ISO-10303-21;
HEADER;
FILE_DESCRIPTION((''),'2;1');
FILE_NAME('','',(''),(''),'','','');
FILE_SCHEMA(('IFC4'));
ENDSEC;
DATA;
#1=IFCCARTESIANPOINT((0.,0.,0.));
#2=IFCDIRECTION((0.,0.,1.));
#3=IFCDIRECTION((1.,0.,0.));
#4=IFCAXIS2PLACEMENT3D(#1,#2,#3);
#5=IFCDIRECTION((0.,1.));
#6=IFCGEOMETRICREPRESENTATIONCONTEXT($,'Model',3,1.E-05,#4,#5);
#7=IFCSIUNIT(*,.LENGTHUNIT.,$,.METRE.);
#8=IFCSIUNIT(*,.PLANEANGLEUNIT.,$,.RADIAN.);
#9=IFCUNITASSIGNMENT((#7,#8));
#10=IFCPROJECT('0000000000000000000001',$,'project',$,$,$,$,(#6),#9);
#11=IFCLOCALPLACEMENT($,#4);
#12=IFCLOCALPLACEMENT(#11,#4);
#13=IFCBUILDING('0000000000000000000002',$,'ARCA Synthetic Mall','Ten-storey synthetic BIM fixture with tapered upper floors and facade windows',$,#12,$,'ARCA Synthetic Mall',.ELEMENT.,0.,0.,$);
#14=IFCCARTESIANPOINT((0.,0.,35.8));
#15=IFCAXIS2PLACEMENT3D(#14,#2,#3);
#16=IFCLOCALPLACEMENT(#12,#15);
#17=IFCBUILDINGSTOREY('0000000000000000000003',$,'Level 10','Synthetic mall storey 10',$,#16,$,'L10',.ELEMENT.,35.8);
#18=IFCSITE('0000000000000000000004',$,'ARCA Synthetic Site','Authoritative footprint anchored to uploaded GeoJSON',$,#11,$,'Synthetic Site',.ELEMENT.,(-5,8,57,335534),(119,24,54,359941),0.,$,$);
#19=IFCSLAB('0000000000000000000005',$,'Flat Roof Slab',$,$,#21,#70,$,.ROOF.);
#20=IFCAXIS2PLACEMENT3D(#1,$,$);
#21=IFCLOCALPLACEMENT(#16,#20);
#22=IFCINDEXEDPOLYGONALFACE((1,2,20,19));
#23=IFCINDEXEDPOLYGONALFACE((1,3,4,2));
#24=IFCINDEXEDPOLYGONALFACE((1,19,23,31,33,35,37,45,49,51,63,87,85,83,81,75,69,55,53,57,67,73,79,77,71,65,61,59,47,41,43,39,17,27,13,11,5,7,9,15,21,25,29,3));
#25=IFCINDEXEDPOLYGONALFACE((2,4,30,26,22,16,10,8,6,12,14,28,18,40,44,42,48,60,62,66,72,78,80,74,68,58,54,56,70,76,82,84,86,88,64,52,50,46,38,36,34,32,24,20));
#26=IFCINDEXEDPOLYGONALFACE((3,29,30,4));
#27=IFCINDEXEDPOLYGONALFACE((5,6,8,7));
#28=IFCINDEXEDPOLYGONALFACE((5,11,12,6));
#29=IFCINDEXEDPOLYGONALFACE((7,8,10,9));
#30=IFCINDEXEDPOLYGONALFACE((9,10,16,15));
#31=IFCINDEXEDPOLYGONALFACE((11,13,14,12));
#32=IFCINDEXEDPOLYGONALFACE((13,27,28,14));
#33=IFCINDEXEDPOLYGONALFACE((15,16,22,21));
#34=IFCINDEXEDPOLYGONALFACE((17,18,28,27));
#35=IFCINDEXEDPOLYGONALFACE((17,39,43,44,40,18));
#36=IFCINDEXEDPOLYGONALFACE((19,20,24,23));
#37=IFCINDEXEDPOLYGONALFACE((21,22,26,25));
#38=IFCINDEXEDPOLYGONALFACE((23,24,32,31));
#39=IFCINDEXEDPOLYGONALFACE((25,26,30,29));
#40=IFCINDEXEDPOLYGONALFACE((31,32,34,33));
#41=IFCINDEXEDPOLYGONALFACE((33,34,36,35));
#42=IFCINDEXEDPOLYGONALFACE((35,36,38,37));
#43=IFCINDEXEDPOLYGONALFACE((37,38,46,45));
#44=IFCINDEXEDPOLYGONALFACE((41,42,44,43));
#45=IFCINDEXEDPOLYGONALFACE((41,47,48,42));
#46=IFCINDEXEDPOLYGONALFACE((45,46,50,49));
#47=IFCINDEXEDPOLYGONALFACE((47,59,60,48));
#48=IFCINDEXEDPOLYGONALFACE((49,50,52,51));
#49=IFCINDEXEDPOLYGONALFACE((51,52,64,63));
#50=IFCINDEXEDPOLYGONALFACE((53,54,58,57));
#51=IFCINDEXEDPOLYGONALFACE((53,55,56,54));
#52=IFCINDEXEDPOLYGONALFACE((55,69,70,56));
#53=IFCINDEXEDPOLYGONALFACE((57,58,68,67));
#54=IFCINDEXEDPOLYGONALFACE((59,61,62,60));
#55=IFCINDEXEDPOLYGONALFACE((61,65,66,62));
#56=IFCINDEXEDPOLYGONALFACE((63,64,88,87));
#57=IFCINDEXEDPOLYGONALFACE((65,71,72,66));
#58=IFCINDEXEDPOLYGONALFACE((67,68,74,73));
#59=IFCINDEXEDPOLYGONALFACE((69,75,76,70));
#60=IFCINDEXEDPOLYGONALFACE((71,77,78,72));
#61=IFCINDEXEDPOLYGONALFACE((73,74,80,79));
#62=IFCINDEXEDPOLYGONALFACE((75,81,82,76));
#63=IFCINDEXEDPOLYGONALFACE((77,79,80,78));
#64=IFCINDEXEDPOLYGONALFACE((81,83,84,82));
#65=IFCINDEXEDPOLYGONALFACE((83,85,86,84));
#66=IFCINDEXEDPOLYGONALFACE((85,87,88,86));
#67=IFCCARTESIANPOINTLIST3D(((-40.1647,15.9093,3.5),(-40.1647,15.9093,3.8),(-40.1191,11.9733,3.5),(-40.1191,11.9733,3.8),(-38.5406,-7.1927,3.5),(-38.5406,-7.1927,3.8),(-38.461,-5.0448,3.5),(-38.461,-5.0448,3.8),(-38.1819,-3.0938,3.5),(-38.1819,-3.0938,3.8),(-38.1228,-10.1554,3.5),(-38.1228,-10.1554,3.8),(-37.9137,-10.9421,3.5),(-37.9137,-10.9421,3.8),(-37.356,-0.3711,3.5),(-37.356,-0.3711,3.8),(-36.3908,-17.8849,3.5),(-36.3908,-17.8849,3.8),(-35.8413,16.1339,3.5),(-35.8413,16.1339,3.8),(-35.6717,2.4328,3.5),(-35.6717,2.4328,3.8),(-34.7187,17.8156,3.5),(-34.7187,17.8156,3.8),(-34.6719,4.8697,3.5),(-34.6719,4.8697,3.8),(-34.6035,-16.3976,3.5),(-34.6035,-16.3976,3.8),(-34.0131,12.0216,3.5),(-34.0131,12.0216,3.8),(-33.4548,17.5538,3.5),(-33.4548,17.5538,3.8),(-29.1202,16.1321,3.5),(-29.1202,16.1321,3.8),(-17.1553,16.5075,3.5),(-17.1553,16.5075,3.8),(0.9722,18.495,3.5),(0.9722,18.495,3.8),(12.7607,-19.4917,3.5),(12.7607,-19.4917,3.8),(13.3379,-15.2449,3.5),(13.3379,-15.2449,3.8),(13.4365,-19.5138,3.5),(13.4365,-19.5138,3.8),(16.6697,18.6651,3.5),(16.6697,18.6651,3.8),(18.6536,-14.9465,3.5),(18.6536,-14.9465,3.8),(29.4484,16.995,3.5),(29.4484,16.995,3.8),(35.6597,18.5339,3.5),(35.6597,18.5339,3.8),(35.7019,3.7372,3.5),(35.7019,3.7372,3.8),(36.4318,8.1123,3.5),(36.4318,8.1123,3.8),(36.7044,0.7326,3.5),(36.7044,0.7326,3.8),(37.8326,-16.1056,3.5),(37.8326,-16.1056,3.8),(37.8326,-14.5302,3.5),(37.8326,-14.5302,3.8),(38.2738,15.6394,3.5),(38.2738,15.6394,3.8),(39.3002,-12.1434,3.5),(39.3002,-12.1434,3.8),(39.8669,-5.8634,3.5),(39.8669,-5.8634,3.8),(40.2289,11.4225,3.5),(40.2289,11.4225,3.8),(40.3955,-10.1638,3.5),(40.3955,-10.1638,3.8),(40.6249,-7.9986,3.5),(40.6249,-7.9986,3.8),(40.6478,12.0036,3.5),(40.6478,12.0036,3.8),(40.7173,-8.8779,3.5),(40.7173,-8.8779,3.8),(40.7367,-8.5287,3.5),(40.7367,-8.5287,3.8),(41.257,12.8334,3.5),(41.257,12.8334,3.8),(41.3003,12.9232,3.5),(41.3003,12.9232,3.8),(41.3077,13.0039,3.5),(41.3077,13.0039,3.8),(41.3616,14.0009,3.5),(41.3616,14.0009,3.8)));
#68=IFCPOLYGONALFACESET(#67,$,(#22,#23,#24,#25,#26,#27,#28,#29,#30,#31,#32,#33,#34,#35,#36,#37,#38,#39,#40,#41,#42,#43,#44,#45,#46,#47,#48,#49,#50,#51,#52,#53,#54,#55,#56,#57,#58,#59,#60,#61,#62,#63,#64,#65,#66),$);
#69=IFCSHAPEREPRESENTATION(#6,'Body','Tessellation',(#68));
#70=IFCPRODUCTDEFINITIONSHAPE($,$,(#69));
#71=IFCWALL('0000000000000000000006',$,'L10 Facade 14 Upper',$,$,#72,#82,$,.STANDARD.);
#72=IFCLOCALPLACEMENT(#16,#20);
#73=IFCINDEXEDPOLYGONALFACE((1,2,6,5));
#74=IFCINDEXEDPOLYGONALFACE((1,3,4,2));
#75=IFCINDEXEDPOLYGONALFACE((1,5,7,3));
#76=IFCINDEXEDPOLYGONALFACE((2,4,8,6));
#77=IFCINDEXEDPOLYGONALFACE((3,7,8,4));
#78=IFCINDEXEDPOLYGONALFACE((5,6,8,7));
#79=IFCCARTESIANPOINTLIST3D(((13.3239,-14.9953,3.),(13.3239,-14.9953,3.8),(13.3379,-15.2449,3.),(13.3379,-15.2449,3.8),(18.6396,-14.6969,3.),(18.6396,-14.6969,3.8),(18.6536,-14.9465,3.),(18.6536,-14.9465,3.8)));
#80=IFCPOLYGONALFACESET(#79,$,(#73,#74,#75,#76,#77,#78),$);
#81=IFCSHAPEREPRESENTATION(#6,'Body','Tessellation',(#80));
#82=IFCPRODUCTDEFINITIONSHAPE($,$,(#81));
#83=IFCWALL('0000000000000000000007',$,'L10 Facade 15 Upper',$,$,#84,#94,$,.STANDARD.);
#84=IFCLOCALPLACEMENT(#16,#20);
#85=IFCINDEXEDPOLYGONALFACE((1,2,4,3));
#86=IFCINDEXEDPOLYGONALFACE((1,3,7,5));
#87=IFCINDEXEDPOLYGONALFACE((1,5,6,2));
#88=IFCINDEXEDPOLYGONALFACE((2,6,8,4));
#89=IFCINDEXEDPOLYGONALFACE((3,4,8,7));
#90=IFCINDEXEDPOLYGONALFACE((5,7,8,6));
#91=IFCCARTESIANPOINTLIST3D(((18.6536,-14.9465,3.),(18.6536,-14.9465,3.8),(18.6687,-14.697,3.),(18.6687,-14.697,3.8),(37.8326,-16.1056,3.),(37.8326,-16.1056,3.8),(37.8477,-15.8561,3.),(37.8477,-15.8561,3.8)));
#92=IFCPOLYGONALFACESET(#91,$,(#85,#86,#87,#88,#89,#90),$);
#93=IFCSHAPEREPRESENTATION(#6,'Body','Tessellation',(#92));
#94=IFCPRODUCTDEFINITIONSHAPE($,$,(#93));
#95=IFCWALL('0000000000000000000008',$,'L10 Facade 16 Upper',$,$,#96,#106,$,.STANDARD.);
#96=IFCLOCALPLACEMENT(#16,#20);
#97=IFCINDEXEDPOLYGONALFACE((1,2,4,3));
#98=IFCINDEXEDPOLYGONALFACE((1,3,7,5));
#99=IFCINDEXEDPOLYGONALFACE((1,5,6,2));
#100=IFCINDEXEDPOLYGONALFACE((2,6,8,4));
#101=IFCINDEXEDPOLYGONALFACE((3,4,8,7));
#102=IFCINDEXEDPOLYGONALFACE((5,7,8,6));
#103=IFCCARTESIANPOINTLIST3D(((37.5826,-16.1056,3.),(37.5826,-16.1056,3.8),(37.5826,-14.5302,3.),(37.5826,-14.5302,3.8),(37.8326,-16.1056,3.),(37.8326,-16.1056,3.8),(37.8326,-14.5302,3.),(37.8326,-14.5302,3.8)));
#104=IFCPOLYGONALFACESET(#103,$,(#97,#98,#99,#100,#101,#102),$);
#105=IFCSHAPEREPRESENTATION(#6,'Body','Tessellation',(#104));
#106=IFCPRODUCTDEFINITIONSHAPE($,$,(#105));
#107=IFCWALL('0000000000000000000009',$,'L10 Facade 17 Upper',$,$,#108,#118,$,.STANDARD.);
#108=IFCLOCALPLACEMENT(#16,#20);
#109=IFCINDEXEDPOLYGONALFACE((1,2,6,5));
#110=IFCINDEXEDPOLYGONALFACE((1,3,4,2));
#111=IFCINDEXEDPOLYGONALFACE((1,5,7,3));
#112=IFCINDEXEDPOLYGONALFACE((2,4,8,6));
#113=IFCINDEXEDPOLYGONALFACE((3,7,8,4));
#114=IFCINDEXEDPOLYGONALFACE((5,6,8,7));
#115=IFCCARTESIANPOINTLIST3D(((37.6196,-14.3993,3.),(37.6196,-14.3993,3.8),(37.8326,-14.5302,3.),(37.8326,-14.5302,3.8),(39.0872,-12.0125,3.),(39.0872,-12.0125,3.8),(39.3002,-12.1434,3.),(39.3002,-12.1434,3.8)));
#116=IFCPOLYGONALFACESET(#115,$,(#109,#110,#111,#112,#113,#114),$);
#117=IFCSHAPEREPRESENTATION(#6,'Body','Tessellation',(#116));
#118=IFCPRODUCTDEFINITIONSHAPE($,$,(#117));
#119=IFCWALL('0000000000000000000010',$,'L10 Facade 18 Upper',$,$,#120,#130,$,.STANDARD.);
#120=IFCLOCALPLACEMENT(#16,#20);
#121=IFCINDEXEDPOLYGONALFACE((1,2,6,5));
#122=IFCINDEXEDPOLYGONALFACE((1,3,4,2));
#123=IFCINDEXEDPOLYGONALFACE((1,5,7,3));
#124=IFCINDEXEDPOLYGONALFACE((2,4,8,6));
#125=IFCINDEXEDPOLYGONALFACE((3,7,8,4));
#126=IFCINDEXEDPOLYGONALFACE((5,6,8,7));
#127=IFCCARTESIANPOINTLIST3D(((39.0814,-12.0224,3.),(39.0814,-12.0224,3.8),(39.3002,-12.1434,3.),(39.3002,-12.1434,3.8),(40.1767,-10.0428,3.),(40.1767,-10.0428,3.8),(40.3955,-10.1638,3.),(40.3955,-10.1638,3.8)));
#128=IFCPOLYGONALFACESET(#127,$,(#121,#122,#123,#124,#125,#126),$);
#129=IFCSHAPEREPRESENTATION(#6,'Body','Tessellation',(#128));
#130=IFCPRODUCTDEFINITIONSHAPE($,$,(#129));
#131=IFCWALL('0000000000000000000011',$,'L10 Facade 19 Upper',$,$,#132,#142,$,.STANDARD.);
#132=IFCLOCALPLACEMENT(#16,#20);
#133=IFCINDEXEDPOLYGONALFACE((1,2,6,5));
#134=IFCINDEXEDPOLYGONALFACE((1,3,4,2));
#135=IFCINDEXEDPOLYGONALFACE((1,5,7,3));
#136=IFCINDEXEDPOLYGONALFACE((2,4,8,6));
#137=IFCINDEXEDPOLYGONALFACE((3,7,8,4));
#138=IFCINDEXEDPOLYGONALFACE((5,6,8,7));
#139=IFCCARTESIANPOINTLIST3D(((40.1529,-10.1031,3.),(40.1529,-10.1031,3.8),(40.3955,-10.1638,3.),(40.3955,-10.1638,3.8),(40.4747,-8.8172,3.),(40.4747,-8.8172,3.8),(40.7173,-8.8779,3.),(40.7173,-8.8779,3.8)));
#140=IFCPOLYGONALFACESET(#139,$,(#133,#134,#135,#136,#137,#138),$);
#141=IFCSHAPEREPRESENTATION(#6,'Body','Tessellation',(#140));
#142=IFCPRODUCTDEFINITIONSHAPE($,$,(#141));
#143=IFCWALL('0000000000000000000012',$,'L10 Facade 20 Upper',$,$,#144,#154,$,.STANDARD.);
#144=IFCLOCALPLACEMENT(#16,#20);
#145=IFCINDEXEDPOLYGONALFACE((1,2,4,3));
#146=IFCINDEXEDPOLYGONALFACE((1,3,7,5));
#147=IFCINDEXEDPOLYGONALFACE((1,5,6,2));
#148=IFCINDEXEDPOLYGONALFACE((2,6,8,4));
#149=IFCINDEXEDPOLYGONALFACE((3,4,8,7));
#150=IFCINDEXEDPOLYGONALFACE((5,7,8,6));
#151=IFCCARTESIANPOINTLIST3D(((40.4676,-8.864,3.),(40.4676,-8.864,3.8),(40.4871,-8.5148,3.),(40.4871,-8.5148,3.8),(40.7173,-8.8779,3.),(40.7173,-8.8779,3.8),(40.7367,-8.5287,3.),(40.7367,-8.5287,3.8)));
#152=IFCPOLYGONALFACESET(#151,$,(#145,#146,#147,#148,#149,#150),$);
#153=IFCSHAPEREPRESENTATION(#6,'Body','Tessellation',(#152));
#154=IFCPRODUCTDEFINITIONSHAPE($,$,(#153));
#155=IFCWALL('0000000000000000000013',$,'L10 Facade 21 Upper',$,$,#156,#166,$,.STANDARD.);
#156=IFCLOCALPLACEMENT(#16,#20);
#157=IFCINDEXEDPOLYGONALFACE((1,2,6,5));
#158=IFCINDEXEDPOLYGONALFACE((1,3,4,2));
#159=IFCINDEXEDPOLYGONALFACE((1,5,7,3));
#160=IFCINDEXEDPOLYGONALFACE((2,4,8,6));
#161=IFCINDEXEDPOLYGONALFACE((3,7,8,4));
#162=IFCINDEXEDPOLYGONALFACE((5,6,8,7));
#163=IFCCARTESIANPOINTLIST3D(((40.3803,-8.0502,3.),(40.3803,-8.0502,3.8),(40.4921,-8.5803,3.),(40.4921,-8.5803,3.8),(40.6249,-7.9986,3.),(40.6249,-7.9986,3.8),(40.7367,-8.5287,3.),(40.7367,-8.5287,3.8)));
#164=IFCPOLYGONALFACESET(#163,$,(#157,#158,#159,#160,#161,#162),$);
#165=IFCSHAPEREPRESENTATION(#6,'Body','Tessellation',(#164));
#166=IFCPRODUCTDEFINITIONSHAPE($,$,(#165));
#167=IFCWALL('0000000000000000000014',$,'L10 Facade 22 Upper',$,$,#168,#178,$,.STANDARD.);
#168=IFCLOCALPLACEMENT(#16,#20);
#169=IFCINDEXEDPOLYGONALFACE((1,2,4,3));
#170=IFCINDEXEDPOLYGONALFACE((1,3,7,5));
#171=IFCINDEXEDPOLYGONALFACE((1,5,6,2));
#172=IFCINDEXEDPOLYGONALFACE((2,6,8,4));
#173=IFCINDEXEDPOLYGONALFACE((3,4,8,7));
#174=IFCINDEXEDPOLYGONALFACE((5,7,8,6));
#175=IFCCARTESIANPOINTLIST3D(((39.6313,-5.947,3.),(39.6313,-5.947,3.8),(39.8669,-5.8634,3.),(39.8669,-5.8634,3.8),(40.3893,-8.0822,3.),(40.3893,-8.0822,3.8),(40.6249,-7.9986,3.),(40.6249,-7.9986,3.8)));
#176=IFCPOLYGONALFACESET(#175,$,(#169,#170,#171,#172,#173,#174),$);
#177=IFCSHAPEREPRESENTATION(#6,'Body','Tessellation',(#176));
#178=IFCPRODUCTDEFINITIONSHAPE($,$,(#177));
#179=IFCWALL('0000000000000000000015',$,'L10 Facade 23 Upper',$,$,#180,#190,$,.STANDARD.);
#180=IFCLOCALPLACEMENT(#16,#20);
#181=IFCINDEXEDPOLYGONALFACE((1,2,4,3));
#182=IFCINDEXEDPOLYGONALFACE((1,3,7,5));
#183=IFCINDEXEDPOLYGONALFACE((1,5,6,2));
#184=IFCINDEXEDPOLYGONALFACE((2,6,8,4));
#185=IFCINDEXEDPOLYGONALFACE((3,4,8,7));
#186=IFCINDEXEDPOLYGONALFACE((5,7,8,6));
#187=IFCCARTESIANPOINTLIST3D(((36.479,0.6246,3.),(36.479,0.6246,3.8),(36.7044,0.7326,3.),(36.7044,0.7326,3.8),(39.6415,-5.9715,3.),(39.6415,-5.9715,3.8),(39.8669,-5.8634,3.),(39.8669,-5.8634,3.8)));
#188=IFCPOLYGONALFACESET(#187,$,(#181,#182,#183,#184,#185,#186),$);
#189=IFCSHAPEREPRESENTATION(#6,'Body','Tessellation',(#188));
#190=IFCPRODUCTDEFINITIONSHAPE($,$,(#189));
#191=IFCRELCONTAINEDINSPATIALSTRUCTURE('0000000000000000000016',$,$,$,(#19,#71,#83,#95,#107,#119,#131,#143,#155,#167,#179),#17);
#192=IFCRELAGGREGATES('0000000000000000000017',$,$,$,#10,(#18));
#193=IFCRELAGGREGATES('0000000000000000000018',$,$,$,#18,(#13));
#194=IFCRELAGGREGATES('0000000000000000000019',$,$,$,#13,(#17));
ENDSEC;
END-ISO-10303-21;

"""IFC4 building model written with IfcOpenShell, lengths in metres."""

from ifc_helpers import new_model, si_unit, direction, frame, origin_with_axes, place, context, project, spatial, polyline, outline, extrude, element, save


model = new_model("IFC4")

# Units and contexts
model_context = context("Model", 3, precision=1e-05, world=origin_with_axes(), true_north=direction((0.0, 1.0)))
ifc_project = project(units=[si_unit("LENGTHUNIT", "METRE"), si_unit("PLANEANGLEUNIT", "RADIAN")], contexts=[model_context])

# Site, building, storey
site_placement = place(None, origin_with_axes())
site = spatial("IfcSite", under=ifc_project, at=site_placement, Name="ARCA Synthetic Site", Description="Authoritative footprint anchored to uploaded GeoJSON", LongName="Synthetic Site", CompositionType="ELEMENT", RefLatitude=(-5, 8, 57, 335534), RefLongitude=(119, 24, 54, 359941), RefElevation=0.0)
building_placement = place(site_placement, origin_with_axes())
building = spatial("IfcBuilding", under=site, at=building_placement, Name="ARCA Synthetic Mall", Description="Ten-storey synthetic BIM fixture with tapered upper floors and facade windows", LongName="ARCA Synthetic Mall", CompositionType="ELEMENT", ElevationOfRefHeight=0.0, ElevationOfTerrain=0.0)
storey_placement = place(building_placement, frame((0.0, 0.0, 35.8), z_axis=(0.0, 0.0, 1.0), x_axis=(1.0, 0.0, 0.0)))
storey = spatial("IfcBuildingStorey", under=building, at=storey_placement, Name="Level 10", Description="Synthetic mall storey 10", LongName="L10", CompositionType="ELEMENT", Elevation=35.8)

# Slab
slab_placement = place(storey_placement, frame((0.0, 0.0, 3.5), z_axis=(0.0, 0.0, 1.0), x_axis=(1.0, 0.0, 0.0)))
element("IfcSlab", 1, at=slab_placement, inside=storey, Name="Flat Roof Slab", PredefinedType="ROOF", context=model_context, shape_type="SweptSolid", body=[
    extrude(outline(polyline([(-40.1191, 11.9733), (-34.0131, 12.0216), (-34.6719, 4.8697), (-35.6717, 2.4328), (-37.356, -0.3711), (-38.1819, -3.0938), (-38.461, -5.0448), (-38.5406, -7.1927), (-38.1228, -10.1554), (-37.9137, -10.9421), (-34.6035, -16.3976), (-36.3908, -17.8849), (12.7607, -19.4917), (13.4365, -19.5138), (13.3379, -15.2449), (18.6536, -14.9465), (37.8326, -16.1056), (37.8326, -14.5302), (39.3002, -12.1434), (40.3955, -10.1638), (40.7173, -8.8779), (40.7367, -8.5287), (40.6249, -7.9986), (39.8669, -5.8634), (36.7044, 0.7326), (35.7019, 3.7372), (36.4318, 8.1123), (40.2289, 11.4225), (40.6478, 12.0036), (41.257, 12.8334), (41.3003, 12.9232), (41.3077, 13.0039), (41.3616, 14.0009), (38.2738, 15.6394), (35.6597, 18.5339), (29.4484, 16.995), (16.6697, 18.6651), (0.9722, 18.495), (-17.1553, 16.5075), (-29.1202, 16.1321), (-33.4548, 17.5538), (-34.7187, 17.8156), (-35.8413, 16.1339), (-40.1647, 15.9093), (-40.1191, 11.9733)])), origin_with_axes(), (0.0, 0.0, 1.0), 0.3),
])

# Walls
wall_1_placement = place(storey_placement, frame((0.0, 0.0, 3.0), z_axis=(0.0, 0.0, 1.0), x_axis=(1.0, 0.0, 0.0)))
element("IfcWall", 2, at=wall_1_placement, inside=storey, Name="L10 Facade 14 Upper", PredefinedType="STANDARD", context=model_context, shape_type="SweptSolid", body=[
    extrude(outline(polyline([(13.3379, -15.2449), (18.6536, -14.9465), (18.6396, -14.6969), (13.3239, -14.9953), (13.3379, -15.2449)])), origin_with_axes(), (0.0, 0.0, 1.0), 0.8),
])
wall_2_placement = place(storey_placement, frame((0.0, 0.0, 3.0), z_axis=(0.0, 0.0, 1.0), x_axis=(1.0, 0.0, 0.0)))
element("IfcWall", 3, at=wall_2_placement, inside=storey, Name="L10 Facade 15 Upper", PredefinedType="STANDARD", context=model_context, shape_type="SweptSolid", body=[
    extrude(outline(polyline([(18.6536, -14.9465), (37.8326, -16.1056), (37.8477, -15.8561), (18.6687, -14.697), (18.6536, -14.9465)])), origin_with_axes(), (0.0, 0.0, 1.0), 0.8),
])
wall_3_placement = place(storey_placement, frame((0.0, 0.0, 3.0), z_axis=(0.0, 0.0, 1.0), x_axis=(1.0, 0.0, 0.0)))
element("IfcWall", 4, at=wall_3_placement, inside=storey, Name="L10 Facade 16 Upper", PredefinedType="STANDARD", context=model_context, shape_type="SweptSolid", body=[
    extrude(outline(polyline([(37.8326, -16.1056), (37.8326, -14.5302), (37.5826, -14.5302), (37.5826, -16.1056), (37.8326, -16.1056)])), origin_with_axes(), (0.0, 0.0, 1.0), 0.8),
])
wall_4_placement = place(storey_placement, frame((0.0, 0.0, 3.0), z_axis=(0.0, 0.0, 1.0), x_axis=(1.0, 0.0, 0.0)))
element("IfcWall", 5, at=wall_4_placement, inside=storey, Name="L10 Facade 17 Upper", PredefinedType="STANDARD", context=model_context, shape_type="SweptSolid", body=[
    extrude(outline(polyline([(37.8326, -14.5302), (39.3002, -12.1434), (39.0872, -12.0125), (37.6196, -14.3993), (37.8326, -14.5302)])), origin_with_axes(), (0.0, 0.0, 1.0), 0.8),
])
wall_5_placement = place(storey_placement, frame((0.0, 0.0, 3.0), z_axis=(0.0, 0.0, 1.0), x_axis=(1.0, 0.0, 0.0)))
element("IfcWall", 6, at=wall_5_placement, inside=storey, Name="L10 Facade 18 Upper", PredefinedType="STANDARD", context=model_context, shape_type="SweptSolid", body=[
    extrude(outline(polyline([(39.3002, -12.1434), (40.3955, -10.1638), (40.1767, -10.0428), (39.0814, -12.0224), (39.3002, -12.1434)])), origin_with_axes(), (0.0, 0.0, 1.0), 0.8),
])
wall_6_placement = place(storey_placement, frame((0.0, 0.0, 3.0), z_axis=(0.0, 0.0, 1.0), x_axis=(1.0, 0.0, 0.0)))
element("IfcWall", 7, at=wall_6_placement, inside=storey, Name="L10 Facade 19 Upper", PredefinedType="STANDARD", context=model_context, shape_type="SweptSolid", body=[
    extrude(outline(polyline([(40.3955, -10.1638), (40.7173, -8.8779), (40.4747, -8.8172), (40.1529, -10.1031), (40.3955, -10.1638)])), origin_with_axes(), (0.0, 0.0, 1.0), 0.8),
])
wall_7_placement = place(storey_placement, frame((0.0, 0.0, 3.0), z_axis=(0.0, 0.0, 1.0), x_axis=(1.0, 0.0, 0.0)))
element("IfcWall", 8, at=wall_7_placement, inside=storey, Name="L10 Facade 20 Upper", PredefinedType="STANDARD", context=model_context, shape_type="SweptSolid", body=[
    extrude(outline(polyline([(40.7173, -8.8779), (40.7367, -8.5287), (40.4871, -8.5148), (40.4676, -8.864), (40.7173, -8.8779)])), origin_with_axes(), (0.0, 0.0, 1.0), 0.8),
])
wall_8_placement = place(storey_placement, frame((0.0, 0.0, 3.0), z_axis=(0.0, 0.0, 1.0), x_axis=(1.0, 0.0, 0.0)))
element("IfcWall", 9, at=wall_8_placement, inside=storey, Name="L10 Facade 21 Upper", PredefinedType="STANDARD", context=model_context, shape_type="SweptSolid", body=[
    extrude(outline(polyline([(40.7367, -8.5287), (40.6249, -7.9986), (40.3803, -8.0502), (40.4921, -8.5803), (40.7367, -8.5287)])), origin_with_axes(), (0.0, 0.0, 1.0), 0.8),
])
wall_9_placement = place(storey_placement, frame((0.0, 0.0, 3.0), z_axis=(0.0, 0.0, 1.0), x_axis=(1.0, 0.0, 0.0)))
element("IfcWall", 10, at=wall_9_placement, inside=storey, Name="L10 Facade 22 Upper", PredefinedType="STANDARD", context=model_context, shape_type="SweptSolid", body=[
    extrude(outline(polyline([(40.6249, -7.9986), (39.8669, -5.8634), (39.6313, -5.947), (40.3893, -8.0822), (40.6249, -7.9986)])), origin_with_axes(), (0.0, 0.0, 1.0), 0.8),
])
wall_10_placement = place(storey_placement, frame((0.0, 0.0, 3.0), z_axis=(0.0, 0.0, 1.0), x_axis=(1.0, 0.0, 0.0)))
element("IfcWall", 11, at=wall_10_placement, inside=storey, Name="L10 Facade 23 Upper", PredefinedType="STANDARD", context=model_context, shape_type="SweptSolid", body=[
    extrude(outline(polyline([(39.8669, -5.8634), (36.7044, 0.7326), (36.479, 0.6246), (39.6415, -5.9715), (39.8669, -5.8634)])), origin_with_axes(), (0.0, 0.0, 1.0), 0.8),
])

save(model, "model.ifc")
